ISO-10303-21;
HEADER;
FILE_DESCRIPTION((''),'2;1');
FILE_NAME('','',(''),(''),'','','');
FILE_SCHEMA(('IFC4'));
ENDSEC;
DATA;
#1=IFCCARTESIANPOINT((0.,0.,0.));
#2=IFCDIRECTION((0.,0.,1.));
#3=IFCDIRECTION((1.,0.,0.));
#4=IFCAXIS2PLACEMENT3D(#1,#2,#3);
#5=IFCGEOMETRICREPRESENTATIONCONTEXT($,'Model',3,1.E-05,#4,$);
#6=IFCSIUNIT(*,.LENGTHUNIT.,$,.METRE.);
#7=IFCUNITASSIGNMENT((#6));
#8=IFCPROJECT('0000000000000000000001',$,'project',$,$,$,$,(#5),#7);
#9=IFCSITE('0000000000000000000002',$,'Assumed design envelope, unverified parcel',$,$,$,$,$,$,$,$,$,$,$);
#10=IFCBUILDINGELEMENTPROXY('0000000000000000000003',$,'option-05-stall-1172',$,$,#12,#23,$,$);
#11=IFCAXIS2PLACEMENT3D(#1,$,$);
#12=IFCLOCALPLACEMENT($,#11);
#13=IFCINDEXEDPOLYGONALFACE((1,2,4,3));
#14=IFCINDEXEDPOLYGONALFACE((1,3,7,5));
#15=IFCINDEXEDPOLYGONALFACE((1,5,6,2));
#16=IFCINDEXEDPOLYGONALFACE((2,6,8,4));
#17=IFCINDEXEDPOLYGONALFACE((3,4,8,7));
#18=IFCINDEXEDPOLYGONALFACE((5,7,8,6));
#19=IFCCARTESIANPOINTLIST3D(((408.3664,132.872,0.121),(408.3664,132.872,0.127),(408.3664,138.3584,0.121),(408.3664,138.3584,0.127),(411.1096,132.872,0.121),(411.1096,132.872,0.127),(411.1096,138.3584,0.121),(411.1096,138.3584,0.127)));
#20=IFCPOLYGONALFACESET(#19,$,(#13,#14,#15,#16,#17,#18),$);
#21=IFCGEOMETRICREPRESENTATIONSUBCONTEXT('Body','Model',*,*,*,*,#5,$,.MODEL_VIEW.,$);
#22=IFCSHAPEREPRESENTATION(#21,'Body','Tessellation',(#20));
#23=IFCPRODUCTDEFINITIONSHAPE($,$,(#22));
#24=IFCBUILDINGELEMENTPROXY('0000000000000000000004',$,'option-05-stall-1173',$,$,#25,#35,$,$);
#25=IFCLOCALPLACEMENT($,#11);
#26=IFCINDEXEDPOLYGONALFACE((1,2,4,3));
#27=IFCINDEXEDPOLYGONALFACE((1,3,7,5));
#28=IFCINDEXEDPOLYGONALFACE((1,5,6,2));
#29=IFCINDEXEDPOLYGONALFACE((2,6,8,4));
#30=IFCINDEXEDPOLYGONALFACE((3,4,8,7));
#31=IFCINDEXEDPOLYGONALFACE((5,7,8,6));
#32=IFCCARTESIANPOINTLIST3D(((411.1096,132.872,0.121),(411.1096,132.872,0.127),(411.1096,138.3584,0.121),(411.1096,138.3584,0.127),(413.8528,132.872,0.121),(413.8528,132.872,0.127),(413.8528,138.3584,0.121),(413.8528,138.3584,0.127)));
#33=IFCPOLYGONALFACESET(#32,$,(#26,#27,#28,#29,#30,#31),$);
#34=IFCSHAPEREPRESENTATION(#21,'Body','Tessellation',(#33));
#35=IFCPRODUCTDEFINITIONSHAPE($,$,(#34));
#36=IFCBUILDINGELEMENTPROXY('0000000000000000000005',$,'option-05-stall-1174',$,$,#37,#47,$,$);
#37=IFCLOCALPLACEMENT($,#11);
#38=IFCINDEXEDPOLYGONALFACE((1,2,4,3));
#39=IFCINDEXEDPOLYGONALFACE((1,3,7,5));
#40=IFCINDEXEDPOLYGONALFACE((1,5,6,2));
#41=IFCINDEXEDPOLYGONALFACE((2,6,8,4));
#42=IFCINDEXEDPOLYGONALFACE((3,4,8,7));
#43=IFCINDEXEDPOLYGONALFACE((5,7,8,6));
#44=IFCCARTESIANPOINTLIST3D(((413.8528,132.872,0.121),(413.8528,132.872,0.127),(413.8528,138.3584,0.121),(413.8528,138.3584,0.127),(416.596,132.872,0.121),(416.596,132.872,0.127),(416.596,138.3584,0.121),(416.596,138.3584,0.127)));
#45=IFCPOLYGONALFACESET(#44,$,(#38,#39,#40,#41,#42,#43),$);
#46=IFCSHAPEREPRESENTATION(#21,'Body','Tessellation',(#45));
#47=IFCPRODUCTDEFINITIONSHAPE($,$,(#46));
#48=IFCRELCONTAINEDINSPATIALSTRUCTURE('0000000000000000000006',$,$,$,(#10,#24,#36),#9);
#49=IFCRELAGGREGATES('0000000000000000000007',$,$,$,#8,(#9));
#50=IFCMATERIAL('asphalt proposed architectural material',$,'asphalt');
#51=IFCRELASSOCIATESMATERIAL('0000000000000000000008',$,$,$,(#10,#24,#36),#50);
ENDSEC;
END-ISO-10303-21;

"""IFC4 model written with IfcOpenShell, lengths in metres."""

from ifc_helpers import new_model, si_unit, frame, origin_with_axes, place, context, subcontext, project, spatial, rectangle, extrude, material, element, save


model = new_model("IFC4")

# Units and contexts
model_context = context("Model", 3, precision=1e-05, world=origin_with_axes())
body_context = subcontext(model_context, "Body", "Model", "MODEL_VIEW")
ifc_project = project(units=[si_unit("LENGTHUNIT", "METRE")], contexts=[model_context])

# Site
site = spatial("IfcSite", under=ifc_project, Name="Assumed design envelope, unverified parcel")

# Building element proxies
ifc_material = material(Name="asphalt proposed architectural material", Category="asphalt")
for number, where, z_axis, x_axis, name in (
    (1, (409.738, 135.6152, 0.121), (0.0, 0.0, 1.0), (1.0, 0.0, 0.0), "option-05-stall-1172"),
    (2, (412.4812, 135.6152, 0.121), (0.0, 0.0, 1.0), (1.0, 0.0, 0.0), "option-05-stall-1173"),
    (3, (415.2244, 135.6152, 0.121), (0.0, 0.0, 1.0), (1.0, 0.0, 0.0), "option-05-stall-1174"),
):
    element("IfcBuildingElementProxy", number, at=place(None, frame(where, z_axis=z_axis, x_axis=x_axis)), inside=site, material=ifc_material, Name=name, context=body_context, shape_type="SweptSolid", body=[
        extrude(rectangle(XDim=2.7432, YDim=5.4864), origin_with_axes(), (0.0, 0.0, 1.0), 0.006),
    ])

save(model, "model.ifc")
